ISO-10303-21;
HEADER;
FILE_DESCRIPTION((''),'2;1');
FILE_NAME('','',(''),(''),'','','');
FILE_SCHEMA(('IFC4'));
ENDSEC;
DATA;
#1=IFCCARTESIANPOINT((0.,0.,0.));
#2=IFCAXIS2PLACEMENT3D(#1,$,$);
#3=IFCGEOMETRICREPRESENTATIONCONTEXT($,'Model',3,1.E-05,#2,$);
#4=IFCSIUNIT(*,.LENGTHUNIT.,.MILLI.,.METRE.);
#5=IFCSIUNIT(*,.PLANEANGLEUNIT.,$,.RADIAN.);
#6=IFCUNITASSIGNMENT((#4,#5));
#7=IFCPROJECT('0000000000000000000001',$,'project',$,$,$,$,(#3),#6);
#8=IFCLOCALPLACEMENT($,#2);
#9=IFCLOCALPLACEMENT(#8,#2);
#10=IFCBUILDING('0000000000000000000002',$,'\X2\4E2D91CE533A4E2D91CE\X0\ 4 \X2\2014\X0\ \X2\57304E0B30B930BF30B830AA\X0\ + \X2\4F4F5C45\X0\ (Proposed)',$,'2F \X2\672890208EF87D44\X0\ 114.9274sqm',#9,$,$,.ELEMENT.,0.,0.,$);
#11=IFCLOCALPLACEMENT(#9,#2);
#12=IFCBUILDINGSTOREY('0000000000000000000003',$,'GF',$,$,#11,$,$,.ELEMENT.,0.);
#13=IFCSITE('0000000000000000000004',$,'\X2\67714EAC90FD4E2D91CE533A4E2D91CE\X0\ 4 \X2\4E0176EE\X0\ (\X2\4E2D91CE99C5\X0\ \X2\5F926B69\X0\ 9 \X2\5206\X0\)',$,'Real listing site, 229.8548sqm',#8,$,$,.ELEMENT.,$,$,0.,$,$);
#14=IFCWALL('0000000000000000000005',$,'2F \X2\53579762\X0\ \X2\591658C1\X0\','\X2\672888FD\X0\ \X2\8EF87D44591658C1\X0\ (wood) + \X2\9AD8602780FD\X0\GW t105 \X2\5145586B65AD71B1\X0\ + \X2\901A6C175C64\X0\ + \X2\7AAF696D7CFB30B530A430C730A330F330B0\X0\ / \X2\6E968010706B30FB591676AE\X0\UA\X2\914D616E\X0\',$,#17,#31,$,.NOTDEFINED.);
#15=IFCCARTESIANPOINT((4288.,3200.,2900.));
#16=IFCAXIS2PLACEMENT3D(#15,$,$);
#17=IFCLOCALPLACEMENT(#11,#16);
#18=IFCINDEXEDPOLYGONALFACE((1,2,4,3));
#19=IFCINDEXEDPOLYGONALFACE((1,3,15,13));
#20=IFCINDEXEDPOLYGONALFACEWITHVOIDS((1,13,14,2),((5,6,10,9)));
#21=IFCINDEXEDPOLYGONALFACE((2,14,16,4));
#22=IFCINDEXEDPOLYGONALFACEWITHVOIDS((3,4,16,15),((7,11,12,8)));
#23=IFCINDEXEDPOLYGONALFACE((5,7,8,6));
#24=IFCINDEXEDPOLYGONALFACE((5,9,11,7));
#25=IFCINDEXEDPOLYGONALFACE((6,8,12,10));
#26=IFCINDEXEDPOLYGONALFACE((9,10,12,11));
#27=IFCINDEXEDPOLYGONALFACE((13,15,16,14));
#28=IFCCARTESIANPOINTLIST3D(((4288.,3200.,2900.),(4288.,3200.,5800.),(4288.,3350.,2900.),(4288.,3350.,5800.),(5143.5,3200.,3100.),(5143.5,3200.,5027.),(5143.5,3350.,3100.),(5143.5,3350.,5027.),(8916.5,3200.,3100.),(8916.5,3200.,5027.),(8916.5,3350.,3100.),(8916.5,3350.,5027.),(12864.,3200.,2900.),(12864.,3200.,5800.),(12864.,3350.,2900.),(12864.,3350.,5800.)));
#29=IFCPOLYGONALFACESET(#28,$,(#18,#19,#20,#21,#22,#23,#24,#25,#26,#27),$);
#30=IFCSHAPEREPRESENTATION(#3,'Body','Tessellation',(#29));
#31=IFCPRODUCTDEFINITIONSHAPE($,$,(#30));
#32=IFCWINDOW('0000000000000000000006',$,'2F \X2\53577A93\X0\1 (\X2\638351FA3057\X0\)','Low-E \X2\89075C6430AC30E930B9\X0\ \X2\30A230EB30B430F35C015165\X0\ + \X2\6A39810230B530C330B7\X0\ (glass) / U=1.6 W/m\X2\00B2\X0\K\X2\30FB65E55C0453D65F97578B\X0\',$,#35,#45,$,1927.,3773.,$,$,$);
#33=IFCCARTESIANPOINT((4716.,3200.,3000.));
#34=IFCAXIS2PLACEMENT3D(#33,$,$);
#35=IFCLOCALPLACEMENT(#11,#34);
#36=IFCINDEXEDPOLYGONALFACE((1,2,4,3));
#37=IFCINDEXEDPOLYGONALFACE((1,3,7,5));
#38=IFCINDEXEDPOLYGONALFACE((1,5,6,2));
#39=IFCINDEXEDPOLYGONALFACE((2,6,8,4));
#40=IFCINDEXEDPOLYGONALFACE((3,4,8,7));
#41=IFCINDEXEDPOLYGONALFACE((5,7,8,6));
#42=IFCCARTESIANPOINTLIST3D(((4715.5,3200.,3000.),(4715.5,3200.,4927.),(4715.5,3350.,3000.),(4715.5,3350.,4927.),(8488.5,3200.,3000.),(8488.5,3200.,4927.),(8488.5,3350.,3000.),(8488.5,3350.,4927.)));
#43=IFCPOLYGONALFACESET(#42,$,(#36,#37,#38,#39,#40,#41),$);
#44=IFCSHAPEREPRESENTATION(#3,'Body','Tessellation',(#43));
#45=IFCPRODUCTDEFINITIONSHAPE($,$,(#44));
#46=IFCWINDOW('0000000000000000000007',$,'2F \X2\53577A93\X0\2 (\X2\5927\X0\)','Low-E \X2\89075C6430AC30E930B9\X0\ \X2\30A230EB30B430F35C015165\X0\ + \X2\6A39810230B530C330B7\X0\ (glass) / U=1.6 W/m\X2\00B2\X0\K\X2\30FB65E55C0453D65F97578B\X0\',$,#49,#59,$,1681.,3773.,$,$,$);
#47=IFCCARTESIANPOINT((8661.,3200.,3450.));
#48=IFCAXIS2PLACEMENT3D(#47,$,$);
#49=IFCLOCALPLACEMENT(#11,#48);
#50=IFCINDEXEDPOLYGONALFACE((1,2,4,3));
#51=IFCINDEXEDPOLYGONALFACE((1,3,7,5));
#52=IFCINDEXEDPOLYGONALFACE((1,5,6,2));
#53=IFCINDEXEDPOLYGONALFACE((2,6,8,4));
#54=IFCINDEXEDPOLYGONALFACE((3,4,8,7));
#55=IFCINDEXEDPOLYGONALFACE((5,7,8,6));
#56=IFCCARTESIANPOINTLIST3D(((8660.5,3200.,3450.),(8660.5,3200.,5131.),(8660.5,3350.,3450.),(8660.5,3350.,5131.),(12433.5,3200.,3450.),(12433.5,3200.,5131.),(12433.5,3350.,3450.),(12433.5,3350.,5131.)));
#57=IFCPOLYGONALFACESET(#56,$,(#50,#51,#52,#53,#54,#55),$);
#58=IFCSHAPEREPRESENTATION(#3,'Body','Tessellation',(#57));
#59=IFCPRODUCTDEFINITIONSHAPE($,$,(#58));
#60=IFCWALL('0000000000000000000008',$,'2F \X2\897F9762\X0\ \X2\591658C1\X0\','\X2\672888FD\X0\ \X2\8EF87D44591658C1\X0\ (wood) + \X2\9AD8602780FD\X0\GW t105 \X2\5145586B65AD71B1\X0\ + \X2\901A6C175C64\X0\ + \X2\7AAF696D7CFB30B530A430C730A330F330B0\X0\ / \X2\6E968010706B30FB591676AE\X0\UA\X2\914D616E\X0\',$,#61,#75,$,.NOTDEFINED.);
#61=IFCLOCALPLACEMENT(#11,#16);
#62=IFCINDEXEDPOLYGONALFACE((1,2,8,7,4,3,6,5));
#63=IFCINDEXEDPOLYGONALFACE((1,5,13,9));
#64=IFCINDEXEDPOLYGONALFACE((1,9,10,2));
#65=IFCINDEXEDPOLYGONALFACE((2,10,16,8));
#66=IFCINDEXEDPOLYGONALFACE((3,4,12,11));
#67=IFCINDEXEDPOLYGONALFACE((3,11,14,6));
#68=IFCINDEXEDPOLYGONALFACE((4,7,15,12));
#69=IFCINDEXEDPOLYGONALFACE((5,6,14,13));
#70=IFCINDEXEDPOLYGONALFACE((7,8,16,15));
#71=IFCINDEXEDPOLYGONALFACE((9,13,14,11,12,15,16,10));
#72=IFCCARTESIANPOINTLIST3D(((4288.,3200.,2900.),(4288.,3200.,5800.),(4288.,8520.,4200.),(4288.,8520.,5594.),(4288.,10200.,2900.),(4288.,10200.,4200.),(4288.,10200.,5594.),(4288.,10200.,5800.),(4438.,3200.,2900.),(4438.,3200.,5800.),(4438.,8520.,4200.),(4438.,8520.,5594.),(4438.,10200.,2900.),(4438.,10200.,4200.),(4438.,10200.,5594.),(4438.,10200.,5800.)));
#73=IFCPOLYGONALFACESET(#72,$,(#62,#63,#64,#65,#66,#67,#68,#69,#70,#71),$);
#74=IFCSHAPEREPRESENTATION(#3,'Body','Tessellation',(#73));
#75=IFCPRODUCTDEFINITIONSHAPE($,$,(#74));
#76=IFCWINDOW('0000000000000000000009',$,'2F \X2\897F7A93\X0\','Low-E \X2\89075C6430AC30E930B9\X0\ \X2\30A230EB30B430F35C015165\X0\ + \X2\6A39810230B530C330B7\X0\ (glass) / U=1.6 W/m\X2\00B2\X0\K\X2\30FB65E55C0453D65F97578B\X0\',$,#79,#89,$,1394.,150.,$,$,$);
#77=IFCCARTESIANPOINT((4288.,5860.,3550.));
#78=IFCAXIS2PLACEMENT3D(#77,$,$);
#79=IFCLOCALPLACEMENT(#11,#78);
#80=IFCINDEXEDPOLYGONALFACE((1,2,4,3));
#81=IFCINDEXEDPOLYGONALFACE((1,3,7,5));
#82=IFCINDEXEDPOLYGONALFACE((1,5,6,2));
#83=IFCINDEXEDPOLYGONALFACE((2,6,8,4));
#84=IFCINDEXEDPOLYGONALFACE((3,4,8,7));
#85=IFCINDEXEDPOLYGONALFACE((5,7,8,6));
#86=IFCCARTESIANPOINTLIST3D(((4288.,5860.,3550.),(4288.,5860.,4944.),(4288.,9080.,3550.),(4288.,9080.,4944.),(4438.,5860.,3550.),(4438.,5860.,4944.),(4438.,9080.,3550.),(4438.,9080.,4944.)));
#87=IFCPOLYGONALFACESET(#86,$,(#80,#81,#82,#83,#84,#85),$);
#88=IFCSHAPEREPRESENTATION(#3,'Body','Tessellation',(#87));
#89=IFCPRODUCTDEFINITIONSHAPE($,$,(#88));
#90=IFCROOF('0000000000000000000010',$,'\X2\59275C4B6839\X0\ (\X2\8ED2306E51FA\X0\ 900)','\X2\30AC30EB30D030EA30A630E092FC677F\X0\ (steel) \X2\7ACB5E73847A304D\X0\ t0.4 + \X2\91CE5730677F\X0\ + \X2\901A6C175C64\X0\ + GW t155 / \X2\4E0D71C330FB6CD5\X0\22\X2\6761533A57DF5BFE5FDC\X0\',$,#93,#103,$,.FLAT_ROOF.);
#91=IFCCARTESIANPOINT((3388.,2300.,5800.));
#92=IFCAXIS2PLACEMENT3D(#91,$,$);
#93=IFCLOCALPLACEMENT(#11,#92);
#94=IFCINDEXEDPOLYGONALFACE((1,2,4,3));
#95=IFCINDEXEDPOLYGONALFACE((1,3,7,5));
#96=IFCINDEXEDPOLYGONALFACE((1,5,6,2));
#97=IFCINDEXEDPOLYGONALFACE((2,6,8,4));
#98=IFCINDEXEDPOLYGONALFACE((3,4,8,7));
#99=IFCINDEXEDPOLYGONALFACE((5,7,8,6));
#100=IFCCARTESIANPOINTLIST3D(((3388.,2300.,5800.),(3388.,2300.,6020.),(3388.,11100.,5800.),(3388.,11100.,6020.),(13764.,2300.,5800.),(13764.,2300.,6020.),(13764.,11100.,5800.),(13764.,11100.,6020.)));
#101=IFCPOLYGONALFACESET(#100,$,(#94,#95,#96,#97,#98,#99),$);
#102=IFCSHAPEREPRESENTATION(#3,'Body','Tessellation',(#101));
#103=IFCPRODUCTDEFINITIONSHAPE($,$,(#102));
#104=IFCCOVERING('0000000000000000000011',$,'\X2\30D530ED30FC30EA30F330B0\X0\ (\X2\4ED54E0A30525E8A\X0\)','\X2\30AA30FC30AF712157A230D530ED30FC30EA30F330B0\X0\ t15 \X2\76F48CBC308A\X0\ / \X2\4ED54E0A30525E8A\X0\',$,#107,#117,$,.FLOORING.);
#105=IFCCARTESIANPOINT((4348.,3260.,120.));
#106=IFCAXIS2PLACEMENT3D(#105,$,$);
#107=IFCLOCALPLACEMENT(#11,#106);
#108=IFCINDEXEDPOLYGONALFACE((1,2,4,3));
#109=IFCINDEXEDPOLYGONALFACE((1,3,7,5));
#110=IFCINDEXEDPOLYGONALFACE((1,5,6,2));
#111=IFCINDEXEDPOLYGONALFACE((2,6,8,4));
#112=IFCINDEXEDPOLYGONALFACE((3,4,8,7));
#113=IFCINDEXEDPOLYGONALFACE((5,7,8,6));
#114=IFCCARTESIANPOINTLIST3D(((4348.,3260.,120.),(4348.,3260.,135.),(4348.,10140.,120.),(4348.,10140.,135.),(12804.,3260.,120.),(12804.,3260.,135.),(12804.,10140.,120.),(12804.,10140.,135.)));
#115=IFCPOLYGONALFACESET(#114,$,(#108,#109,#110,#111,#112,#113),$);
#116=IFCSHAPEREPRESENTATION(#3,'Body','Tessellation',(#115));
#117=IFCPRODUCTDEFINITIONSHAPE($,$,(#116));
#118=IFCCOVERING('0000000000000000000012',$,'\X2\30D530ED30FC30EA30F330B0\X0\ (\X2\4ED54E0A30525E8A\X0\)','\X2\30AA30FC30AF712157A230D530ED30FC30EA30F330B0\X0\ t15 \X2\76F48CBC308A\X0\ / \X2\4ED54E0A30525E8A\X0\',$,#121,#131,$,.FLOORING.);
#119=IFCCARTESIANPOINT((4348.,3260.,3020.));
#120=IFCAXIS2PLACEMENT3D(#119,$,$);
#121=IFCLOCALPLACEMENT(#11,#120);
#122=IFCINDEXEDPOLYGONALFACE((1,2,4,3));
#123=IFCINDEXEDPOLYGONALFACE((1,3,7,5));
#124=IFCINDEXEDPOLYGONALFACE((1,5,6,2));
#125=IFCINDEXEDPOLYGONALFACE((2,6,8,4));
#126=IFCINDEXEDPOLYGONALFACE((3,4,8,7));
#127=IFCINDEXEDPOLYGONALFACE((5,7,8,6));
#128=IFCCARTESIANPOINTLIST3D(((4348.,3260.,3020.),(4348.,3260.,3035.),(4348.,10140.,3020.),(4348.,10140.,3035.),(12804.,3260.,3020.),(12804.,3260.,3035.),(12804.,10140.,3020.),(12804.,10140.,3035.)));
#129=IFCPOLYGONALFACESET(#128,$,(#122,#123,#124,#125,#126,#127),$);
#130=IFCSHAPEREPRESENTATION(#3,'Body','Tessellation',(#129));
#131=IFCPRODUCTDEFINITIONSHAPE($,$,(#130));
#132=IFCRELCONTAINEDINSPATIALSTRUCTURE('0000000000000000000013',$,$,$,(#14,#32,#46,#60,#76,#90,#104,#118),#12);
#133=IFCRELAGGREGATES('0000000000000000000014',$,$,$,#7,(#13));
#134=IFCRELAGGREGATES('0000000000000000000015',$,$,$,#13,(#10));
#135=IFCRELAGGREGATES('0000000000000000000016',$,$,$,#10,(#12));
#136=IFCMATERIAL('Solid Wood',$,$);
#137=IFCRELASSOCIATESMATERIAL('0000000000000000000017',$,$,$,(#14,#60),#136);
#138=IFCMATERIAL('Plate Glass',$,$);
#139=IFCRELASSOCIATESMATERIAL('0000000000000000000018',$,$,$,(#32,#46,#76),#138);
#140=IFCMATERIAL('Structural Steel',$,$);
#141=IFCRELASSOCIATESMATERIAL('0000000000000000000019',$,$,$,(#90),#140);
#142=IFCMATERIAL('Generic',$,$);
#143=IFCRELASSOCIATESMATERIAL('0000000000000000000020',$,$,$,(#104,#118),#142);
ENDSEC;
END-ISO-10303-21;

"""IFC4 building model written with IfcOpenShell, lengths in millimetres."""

from ifc_helpers import new_model, si_unit, frame, frame_2d, origin, place, context, project, spatial, rectangle, extrude, material, element, fill, save


model = new_model("IFC4")

# Units and contexts
model_context = context("Model", 3, precision=1e-05, world=origin())
ifc_project = project(units=[si_unit("LENGTHUNIT", "METRE", prefix="MILLI"), si_unit("PLANEANGLEUNIT", "RADIAN")], contexts=[model_context])

# Site, building, storey
site_placement = place(None, origin())
site = spatial("IfcSite", under=ifc_project, at=site_placement, Name="東京都中野区中野 4 丁目 (中野駅 徒歩 9 分)", ObjectType="Real listing site, 229.8548sqm", CompositionType="ELEMENT", RefElevation=0.0)
building_placement = place(site_placement, origin())
building = spatial("IfcBuilding", under=site, at=building_placement, Name="中野区中野 4 — 地下スタジオ + 住居 (Proposed)", ObjectType="2F 木造軸組 114.9274sqm", CompositionType="ELEMENT", ElevationOfRefHeight=0.0, ElevationOfTerrain=0.0)
storey_placement = place(building_placement, origin())
storey = spatial("IfcBuildingStorey", under=building, at=storey_placement, Name="GF", CompositionType="ELEMENT", Elevation=0.0)

# Shared definitions
ifc_material_1 = material(Name="Solid Wood")

# Shared definitions
ifc_material_2 = material(Name="Plate Glass")

# Wall, openings, windows
wall_1_placement = place(storey_placement, frame((4288.0, 3200.0, 2900.0)))
wall_1 = element("IfcWall", 1, at=wall_1_placement, inside=storey, material=ifc_material_1, Name="2F 南面 外壁", Description="木製 軸組外壁 (wood) + 高性能GW t105 充填断熱 + 通気層 + 窯業系サイディング / 準耐火・外皮UA配慮", PredefinedType="NOTDEFINED", context=model_context, shape_type="SweptSolid", body=[
    extrude(rectangle(XDim=8576.0, YDim=150.0, at=frame_2d((4288.0, 75.0))), frame((4288.0, 3200.0, 2900.0)), (0.0, 0.0, 1.0), 2900.0),
])
opening_1_placement = place(storey_placement, frame((4716.0, 3200.0, 3000.0)))
opening_1 = element("IfcOpeningElement", 2, at=opening_1_placement, cuts=wall_1, PredefinedType="NOTDEFINED", context=model_context, shape_type="SweptSolid", body=[
    extrude(rectangle(XDim=3773.0, YDim=150.0, at=frame_2d((1886.0, 75.0))), frame((4716.0, 3200.0, 3000.0)), (0.0, 0.0, 1.0), 1927.0),
])
opening_2_placement = place(storey_placement, frame((8661.0, 3200.0, 3450.0)))
opening_2 = element("IfcOpeningElement", 3, at=opening_2_placement, cuts=wall_1, PredefinedType="NOTDEFINED", context=model_context, shape_type="SweptSolid", body=[
    extrude(rectangle(XDim=3773.0, YDim=150.0, at=frame_2d((1886.0, 75.0))), frame((8661.0, 3200.0, 3450.0)), (0.0, 0.0, 1.0), 1681.0),
])
window_1_placement = place(storey_placement, frame((4716.0, 3200.0, 3000.0)))
window_1 = element("IfcWindow", 4, at=window_1_placement, inside=storey, material=ifc_material_2, Name="2F 南窓1 (掃出し)", Description="Low-E 複層ガラス アルゴン封入 + 樹脂サッシ (glass) / U=1.6 W/m²K・日射取得型", OverallHeight=1927.0, OverallWidth=3773.0, context=model_context, shape_type="SweptSolid", body=[
    extrude(rectangle(XDim=3773.0, YDim=150.0, at=frame_2d((1886.0, 75.0))), frame((4716.0, 3200.0, 3000.0)), (0.0, 0.0, 1.0), 1927.0),
])
fill(opening_1, window_1)
window_2_placement = place(storey_placement, frame((8661.0, 3200.0, 3450.0)))
window_2 = element("IfcWindow", 5, at=window_2_placement, inside=storey, material=ifc_material_2, Name="2F 南窓2 (大)", Description="Low-E 複層ガラス アルゴン封入 + 樹脂サッシ (glass) / U=1.6 W/m²K・日射取得型", OverallHeight=1681.0, OverallWidth=3773.0, context=model_context, shape_type="SweptSolid", body=[
    extrude(rectangle(XDim=3773.0, YDim=150.0, at=frame_2d((1886.0, 75.0))), frame((8661.0, 3200.0, 3450.0)), (0.0, 0.0, 1.0), 1681.0),
])
fill(opening_2, window_2)

# Wall, opening, window
wall_2_placement = place(storey_placement, frame((4288.0, 3200.0, 2900.0)))
wall_2 = element("IfcWall", 6, at=wall_2_placement, inside=storey, material=ifc_material_1, Name="2F 西面 外壁", Description="木製 軸組外壁 (wood) + 高性能GW t105 充填断熱 + 通気層 + 窯業系サイディング / 準耐火・外皮UA配慮", PredefinedType="NOTDEFINED", context=model_context, shape_type="SweptSolid", body=[
    extrude(rectangle(XDim=150.0, YDim=7000.0, at=frame_2d((75.0, 3500.0))), frame((4288.0, 3200.0, 2900.0)), (0.0, 0.0, 1.0), 2900.0),
])
opening_3_placement = place(storey_placement, frame((4288.0, 5860.0, 3550.0)))
opening_3 = element("IfcOpeningElement", 7, at=opening_3_placement, cuts=wall_2, PredefinedType="NOTDEFINED", context=model_context, shape_type="SweptSolid", body=[
    extrude(rectangle(XDim=150.0, YDim=3220.0, at=frame_2d((75.0, 1610.0))), frame((4288.0, 5860.0, 3550.0)), (0.0, 0.0, 1.0), 1394.0),
])
window_3_placement = place(storey_placement, frame((4288.0, 5860.0, 3550.0)))
window_3 = element("IfcWindow", 8, at=window_3_placement, inside=storey, material=ifc_material_2, Name="2F 西窓", Description="Low-E 複層ガラス アルゴン封入 + 樹脂サッシ (glass) / U=1.6 W/m²K・日射取得型", OverallHeight=1394.0, OverallWidth=150.0, context=model_context, shape_type="SweptSolid", body=[
    extrude(rectangle(XDim=150.0, YDim=3220.0, at=frame_2d((75.0, 1610.0))), frame((4288.0, 5860.0, 3550.0)), (0.0, 0.0, 1.0), 1394.0),
])
fill(opening_3, window_3)

# Roof
ifc_material_3 = material(Name="Structural Steel")
roof_placement = place(storey_placement, frame((3388.0, 2300.0, 5800.0)))
element("IfcRoof", 9, at=roof_placement, inside=storey, material=ifc_material_3, Name="大屋根 (軒の出 900)", Description="ガルバリウム鋼板 (steel) 立平葺き t0.4 + 野地板 + 通気層 + GW t155 / 不燃・法22条区域対応", PredefinedType="FLAT_ROOF", context=model_context, shape_type="SweptSolid", body=[
    extrude(rectangle(XDim=10376.0, YDim=8800.0, at=frame_2d((5188.0, 4400.0))), frame((3388.0, 2300.0, 5800.0)), (0.0, 0.0, 1.0), 220.0),
])

# Coverings
ifc_material_4 = material(Name="Generic")
covering_1_placement = place(storey_placement, frame((4348.0, 3260.0, 120.0)))
element("IfcCovering", 10, at=covering_1_placement, inside=storey, material=ifc_material_4, Name="フローリング (仕上げ床)", Description="オーク無垢フローリング t15 直貼り / 仕上げ床", PredefinedType="FLOORING", context=model_context, shape_type="SweptSolid", body=[
    extrude(rectangle(XDim=8456.0, YDim=6880.0, at=frame_2d((4228.0, 3440.0))), frame((4348.0, 3260.0, 120.0)), (0.0, 0.0, 1.0), 15.0),
])
covering_2_placement = place(storey_placement, frame((4348.0, 3260.0, 3020.0)))
element("IfcCovering", 11, at=covering_2_placement, inside=storey, material=ifc_material_4, Name="フローリング (仕上げ床)", Description="オーク無垢フローリング t15 直貼り / 仕上げ床", PredefinedType="FLOORING", context=model_context, shape_type="SweptSolid", body=[
    extrude(rectangle(XDim=8456.0, YDim=6880.0, at=frame_2d((4228.0, 3440.0))), frame((4348.0, 3260.0, 3020.0)), (0.0, 0.0, 1.0), 15.0),
])

save(model, "model.ifc")
